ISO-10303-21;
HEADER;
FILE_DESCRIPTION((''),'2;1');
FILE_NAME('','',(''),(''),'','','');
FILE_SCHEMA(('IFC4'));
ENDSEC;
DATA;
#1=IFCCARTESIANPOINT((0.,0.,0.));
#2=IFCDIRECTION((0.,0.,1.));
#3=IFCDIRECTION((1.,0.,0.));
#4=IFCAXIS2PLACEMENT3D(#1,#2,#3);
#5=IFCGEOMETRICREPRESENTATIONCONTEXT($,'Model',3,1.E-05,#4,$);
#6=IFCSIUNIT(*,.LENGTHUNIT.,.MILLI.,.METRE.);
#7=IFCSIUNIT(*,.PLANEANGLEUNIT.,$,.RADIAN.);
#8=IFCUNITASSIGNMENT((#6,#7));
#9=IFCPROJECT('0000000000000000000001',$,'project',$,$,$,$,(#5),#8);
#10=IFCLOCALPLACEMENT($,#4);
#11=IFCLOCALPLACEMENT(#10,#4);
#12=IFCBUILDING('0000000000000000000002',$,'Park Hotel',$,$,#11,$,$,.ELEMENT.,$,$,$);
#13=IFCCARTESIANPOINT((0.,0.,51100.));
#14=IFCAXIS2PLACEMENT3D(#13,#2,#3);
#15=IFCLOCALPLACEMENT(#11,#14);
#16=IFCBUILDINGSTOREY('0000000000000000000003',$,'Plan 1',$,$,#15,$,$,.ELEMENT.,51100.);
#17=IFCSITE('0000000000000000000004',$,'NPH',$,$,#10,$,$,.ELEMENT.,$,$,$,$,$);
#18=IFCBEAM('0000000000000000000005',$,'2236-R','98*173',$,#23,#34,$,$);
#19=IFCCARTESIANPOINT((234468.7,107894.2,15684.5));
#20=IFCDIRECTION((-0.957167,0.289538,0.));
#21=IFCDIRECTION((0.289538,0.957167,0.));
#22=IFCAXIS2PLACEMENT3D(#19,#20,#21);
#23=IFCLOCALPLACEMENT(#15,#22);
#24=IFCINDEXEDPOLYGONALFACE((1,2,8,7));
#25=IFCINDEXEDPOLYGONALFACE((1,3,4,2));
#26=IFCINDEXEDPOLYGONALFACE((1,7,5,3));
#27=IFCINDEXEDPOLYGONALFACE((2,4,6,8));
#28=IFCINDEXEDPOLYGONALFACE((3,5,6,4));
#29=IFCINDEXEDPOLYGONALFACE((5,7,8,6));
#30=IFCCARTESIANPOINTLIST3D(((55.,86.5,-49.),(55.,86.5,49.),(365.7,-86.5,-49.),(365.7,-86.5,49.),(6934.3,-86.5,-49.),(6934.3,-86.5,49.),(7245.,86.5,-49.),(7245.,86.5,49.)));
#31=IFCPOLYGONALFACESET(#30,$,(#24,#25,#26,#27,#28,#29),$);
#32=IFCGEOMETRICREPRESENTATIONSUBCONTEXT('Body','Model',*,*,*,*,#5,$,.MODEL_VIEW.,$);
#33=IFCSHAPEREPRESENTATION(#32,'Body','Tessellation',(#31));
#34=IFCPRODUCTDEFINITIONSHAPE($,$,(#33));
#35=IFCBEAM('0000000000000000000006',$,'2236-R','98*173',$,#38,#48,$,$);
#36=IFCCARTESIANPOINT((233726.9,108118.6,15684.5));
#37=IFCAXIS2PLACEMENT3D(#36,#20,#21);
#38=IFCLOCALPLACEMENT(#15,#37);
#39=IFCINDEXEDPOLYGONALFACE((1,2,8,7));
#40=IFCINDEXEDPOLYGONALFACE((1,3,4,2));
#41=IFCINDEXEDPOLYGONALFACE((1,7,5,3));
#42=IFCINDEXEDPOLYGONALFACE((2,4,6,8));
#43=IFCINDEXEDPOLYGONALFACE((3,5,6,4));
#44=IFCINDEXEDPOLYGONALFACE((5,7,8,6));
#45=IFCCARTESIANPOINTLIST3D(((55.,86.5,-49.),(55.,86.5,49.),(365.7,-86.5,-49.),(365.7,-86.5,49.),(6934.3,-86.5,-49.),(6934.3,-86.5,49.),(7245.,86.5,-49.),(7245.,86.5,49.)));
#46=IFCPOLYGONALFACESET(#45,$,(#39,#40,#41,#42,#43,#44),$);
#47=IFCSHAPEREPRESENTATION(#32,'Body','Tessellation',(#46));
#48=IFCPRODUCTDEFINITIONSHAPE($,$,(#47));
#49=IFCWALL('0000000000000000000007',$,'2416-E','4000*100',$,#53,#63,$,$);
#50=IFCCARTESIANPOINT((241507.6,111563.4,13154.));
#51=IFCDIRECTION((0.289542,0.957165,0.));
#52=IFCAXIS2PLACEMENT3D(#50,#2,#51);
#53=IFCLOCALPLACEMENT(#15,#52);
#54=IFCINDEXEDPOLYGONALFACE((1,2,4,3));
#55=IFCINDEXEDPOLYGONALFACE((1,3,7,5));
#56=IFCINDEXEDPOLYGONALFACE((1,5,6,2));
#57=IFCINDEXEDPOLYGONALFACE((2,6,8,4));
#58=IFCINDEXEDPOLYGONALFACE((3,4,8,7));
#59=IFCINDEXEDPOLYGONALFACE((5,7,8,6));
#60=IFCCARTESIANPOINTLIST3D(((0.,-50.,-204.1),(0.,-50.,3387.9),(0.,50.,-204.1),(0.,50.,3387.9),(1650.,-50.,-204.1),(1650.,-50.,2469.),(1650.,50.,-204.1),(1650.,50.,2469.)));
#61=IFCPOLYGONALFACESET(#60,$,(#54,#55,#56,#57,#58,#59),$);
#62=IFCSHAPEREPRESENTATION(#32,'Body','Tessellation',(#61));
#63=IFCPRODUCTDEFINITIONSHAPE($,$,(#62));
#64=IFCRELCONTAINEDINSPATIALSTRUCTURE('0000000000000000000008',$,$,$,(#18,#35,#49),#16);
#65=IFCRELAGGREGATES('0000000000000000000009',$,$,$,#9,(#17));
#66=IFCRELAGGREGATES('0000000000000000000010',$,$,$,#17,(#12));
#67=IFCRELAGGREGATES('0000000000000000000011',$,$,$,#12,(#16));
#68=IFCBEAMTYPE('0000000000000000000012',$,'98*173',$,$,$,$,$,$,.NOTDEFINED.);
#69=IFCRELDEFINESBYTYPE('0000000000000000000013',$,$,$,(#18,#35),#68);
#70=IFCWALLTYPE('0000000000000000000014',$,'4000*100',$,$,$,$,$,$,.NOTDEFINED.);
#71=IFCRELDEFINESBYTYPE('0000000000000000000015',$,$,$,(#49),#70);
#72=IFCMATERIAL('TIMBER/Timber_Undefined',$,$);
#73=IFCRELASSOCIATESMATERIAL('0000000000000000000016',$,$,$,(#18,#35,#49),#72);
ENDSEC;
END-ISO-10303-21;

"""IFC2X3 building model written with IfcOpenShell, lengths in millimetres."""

from ifc_helpers import new_model, si_unit, frame, frame_2d, origin_with_axes, origin_2d_with_axis, place, context, subcontext, project, spatial, rectangle, extrude, clip, halfspace, material, type_object, element, save


model = new_model("IFC2X3")

# Units and contexts
model_context = context("Model", 3, precision=1e-05, world=origin_with_axes())
body_context = subcontext(model_context, "Body", "Model", "MODEL_VIEW")
ifc_project = project(units=[si_unit("LENGTHUNIT", "METRE", prefix="MILLI"), si_unit("PLANEANGLEUNIT", "RADIAN")], contexts=[model_context])

# Site, building, storey
site_placement = place(None, origin_with_axes())
site = spatial("IfcSite", under=ifc_project, at=site_placement, Name="NPH", CompositionType="ELEMENT")
building_placement = place(site_placement, origin_with_axes())
building = spatial("IfcBuilding", under=site, at=building_placement, Name="Park Hotel", CompositionType="ELEMENT")
storey_placement = place(building_placement, frame((0.0, 0.0, 51100.0), z_axis=(0.0, 0.0, 1.0), x_axis=(1.0, 0.0, 0.0)))
storey = spatial("IfcBuildingStorey", under=building, at=storey_placement, Name="Plan 1", CompositionType="ELEMENT", Elevation=51100.0)

# Shared definitions
ifc_material_1 = material(Name="TIMBER/Timber_Undefined")

# Beams
beam_type_1 = type_object("IfcBeamType", Name="98*173", PredefinedType="NOTDEFINED")
for number, where, z_axis, x_axis, name in (
    (1, (234468.7, 107894.2, 15684.5), (-0.957167, 0.289538, 0.0), (0.289538, 0.957167, 0.0), "2236-R"),
    (2, (233726.9, 108118.6, 15684.5), (-0.957167, 0.289538, 0.0), (0.289538, 0.957167, 0.0), "2236-R"),
):
    element("IfcBeam", number, at=place(storey_placement, frame(where, z_axis=z_axis, x_axis=x_axis)), inside=storey, type_object=beam_type_1, material=ifc_material_1, Name=name, Description="98*173", context=body_context, shape_type="Clipping", body=[
        clip(clip(extrude(rectangle(XDim=173.0, YDim=98.0, at=origin_2d_with_axis()), frame((7270.0, 0.0, 0.0), z_axis=(-1.0, 0.0, 0.0), x_axis=(0.0, -1.0, 0.0)), (0.0, 0.0, 1.0), 7270.0), halfspace(frame((55.0, 86.5, -49.0), z_axis=(-0.486528, -0.873665, 0.0), x_axis=(0.0, 0.0, 1.0)), False)), halfspace(frame((7245.0, 86.5, 49.0), z_axis=(0.486529, -0.873664, 0.0), x_axis=(0.0, 0.0, -1.0)), False)),
    ])

# Wall
wall_type_1 = type_object("IfcWallType", Name="4000*100", PredefinedType="NOTDEFINED")
wall_1_placement = place(storey_placement, frame((241507.6, 111563.4, 13154.0), z_axis=(0.0, 0.0, 1.0), x_axis=(0.289542, 0.957165, 0.0)))
element("IfcWall", 3, at=wall_1_placement, inside=storey, type_object=wall_type_1, material=ifc_material_1, Name="2416-E", Description="4000*100", context=body_context, shape_type="Clipping", body=[
    clip(extrude(rectangle(XDim=1650.0, YDim=100.0, at=frame_2d((0.0, 825.0), x_axis=(0.0, -1.0))), frame((0.0, 0.0, -204.1), z_axis=(0.0, 0.0, 1.0), x_axis=(0.0, -1.0, 0.0)), (0.0, 0.0, 1.0), 4000.0), halfspace(frame((-732.8, 50.0, 3795.9), z_axis=(0.486531, 0.000002, 0.873663), x_axis=(0.873663, 0.000002, -0.486531)), False)),
])

save(model, "model.ifc")
